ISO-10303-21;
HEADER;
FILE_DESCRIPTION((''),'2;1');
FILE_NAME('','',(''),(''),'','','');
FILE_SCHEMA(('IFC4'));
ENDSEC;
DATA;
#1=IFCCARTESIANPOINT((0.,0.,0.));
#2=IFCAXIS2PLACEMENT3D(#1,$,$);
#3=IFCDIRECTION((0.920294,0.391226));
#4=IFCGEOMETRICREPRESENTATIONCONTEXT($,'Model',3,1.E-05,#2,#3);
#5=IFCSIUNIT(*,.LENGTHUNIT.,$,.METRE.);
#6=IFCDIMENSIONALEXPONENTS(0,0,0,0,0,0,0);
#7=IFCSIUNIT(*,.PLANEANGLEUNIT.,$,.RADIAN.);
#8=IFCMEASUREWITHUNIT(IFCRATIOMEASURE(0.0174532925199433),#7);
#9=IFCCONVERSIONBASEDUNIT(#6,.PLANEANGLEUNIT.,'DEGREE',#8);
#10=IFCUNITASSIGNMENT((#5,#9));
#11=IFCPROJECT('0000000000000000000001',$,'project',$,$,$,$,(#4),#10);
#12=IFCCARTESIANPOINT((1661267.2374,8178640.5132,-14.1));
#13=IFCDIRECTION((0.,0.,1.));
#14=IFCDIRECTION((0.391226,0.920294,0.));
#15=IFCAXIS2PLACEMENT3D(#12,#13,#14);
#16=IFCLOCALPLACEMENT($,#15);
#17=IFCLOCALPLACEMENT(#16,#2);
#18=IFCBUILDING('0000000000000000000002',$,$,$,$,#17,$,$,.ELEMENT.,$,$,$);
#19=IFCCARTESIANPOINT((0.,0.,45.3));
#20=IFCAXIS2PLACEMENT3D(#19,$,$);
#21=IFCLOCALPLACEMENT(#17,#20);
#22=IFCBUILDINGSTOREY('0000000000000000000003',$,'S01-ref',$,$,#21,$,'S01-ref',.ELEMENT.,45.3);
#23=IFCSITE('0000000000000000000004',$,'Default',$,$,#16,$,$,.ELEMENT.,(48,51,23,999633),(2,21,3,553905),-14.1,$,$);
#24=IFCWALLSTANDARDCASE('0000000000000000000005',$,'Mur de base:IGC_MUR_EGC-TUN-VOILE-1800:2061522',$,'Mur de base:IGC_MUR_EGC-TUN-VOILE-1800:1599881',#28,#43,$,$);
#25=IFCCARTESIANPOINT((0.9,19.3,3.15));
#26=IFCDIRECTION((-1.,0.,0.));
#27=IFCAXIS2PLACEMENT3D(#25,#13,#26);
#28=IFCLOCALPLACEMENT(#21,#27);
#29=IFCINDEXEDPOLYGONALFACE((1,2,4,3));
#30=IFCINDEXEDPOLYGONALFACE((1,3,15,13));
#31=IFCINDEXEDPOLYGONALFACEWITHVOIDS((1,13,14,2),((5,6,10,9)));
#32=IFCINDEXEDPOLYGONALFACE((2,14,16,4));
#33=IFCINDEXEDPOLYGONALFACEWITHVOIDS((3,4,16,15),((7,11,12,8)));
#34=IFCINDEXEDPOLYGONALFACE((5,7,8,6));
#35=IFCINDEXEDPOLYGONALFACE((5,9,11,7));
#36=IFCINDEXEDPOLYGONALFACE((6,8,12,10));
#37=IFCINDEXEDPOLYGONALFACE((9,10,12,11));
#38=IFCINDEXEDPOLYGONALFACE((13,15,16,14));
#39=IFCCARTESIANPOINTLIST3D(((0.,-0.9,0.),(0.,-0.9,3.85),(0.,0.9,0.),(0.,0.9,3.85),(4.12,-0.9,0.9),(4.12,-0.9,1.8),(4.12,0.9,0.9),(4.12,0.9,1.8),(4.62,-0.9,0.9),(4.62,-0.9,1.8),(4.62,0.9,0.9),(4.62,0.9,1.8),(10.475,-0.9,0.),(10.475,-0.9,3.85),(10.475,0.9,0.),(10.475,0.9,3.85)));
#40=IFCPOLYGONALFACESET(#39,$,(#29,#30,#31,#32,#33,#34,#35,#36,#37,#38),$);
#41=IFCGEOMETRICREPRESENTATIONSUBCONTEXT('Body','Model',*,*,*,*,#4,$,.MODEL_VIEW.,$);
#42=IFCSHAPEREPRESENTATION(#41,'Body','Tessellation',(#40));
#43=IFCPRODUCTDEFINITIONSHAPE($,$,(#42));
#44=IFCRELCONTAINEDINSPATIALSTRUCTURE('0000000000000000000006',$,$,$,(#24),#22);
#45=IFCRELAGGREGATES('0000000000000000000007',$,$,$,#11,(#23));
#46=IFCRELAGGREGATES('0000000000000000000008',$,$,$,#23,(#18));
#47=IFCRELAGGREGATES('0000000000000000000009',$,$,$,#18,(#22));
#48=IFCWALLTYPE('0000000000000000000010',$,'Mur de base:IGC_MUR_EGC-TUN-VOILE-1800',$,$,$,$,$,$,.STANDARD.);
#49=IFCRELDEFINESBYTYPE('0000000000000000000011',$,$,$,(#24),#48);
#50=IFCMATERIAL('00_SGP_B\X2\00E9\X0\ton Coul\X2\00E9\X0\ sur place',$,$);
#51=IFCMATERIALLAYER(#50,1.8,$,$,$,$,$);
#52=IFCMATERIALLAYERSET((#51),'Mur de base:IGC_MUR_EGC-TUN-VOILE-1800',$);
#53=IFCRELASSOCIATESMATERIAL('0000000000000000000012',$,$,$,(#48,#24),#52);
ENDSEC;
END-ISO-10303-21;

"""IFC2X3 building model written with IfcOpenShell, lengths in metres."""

from ifc_helpers import new_model, entity, si_unit, converted_unit, direction, frame, frame_2d, origin, place, context, subcontext, project, spatial, rectangle, extrude, material, layer, layer_set, layer_usage, type_object, element, save


model = new_model("IFC2X3")

# Units and contexts
model_context = context("Model", 3, precision=1e-05, world=origin(), true_north=direction((0.920294, 0.391226)))
body_context = subcontext(model_context, "Body", "Model", "MODEL_VIEW")
ifc_project = project(units=[si_unit("LENGTHUNIT", "METRE"), converted_unit("PLANEANGLEUNIT", "DEGREE", entity("IfcRatioMeasure", 0.0174532925199433), si_unit("PLANEANGLEUNIT", "RADIAN"), dimensions=[0, 0, 0, 0, 0, 0, 0])], contexts=[model_context])

# Site, building, storey
site_placement = place(None, frame((1661267.2374, 8178640.5132, -14.1), z_axis=(0.0, 0.0, 1.0), x_axis=(0.391226, 0.920294, 0.0)))
site = spatial("IfcSite", under=ifc_project, at=site_placement, Name="Default", CompositionType="ELEMENT", RefLatitude=(48, 51, 23, 999633), RefLongitude=(2, 21, 3, 553905), RefElevation=-14.1)
building_placement = place(site_placement, origin())
building = spatial("IfcBuilding", under=site, at=building_placement, CompositionType="ELEMENT")
storey_placement = place(building_placement, frame((0.0, 0.0, 45.3)))
storey = spatial("IfcBuildingStorey", under=building, at=storey_placement, Name="S01-ref", LongName="S01-ref", CompositionType="ELEMENT", Elevation=45.3)

# Shared definitions
ifc_material_1 = material(Name="00_SGP_Béton Coulé sur place")

# Shared definitions
ifc_layer_1 = layer(ifc_material_1, 1.8)
ifc_layer_set_1 = layer_set([ifc_layer_1], Name="Mur de base:IGC_MUR_EGC-TUN-VOILE-1800")
wall_type_1 = type_object("IfcWallType", Name="Mur de base:IGC_MUR_EGC-TUN-VOILE-1800", PredefinedType="STANDARD", material=ifc_layer_set_1)

# Wall, opening
ifc_layer_usage_1 = layer_usage(ifc_layer_set_1, "AXIS2", "NEGATIVE", 0.9)
wall_1_placement = place(storey_placement, frame((0.9, 19.3, 3.15), z_axis=(0.0, 0.0, 1.0), x_axis=(-1.0, 0.0, 0.0)))
wall_1 = element("IfcWallStandardCase", 1, at=wall_1_placement, inside=storey, type_object=wall_type_1, material=ifc_layer_usage_1, Name="Mur de base:IGC_MUR_EGC-TUN-VOILE-1800:2061522", ObjectType="Mur de base:IGC_MUR_EGC-TUN-VOILE-1800:1599881", context=body_context, shape_type="SweptSolid", body=[
    extrude(rectangle(XDim=10.475, YDim=1.8, at=frame_2d((5.2375, 0.0), x_axis=(-1.0, 0.0))), origin(), (0.0, 0.0, 1.0), 3.85),
])
opening_1_placement = place(wall_1_placement, origin())
element("IfcOpeningElement", 2, at=opening_1_placement, cuts=wall_1, ObjectType="Opening", context=body_context, shape_type="SweptSolid", body=[
    extrude(rectangle(XDim=0.9, YDim=0.5, at=frame_2d((0.0, 0.0), x_axis=(1.0, 0.0))), frame((4.37, -1.0524, 1.35), z_axis=(0.0, 1.0, 0.0), x_axis=(0.0, 0.0, -1.0)), (0.0, 0.0, 1.0), 3.9048),
])

save(model, "model.ifc")
